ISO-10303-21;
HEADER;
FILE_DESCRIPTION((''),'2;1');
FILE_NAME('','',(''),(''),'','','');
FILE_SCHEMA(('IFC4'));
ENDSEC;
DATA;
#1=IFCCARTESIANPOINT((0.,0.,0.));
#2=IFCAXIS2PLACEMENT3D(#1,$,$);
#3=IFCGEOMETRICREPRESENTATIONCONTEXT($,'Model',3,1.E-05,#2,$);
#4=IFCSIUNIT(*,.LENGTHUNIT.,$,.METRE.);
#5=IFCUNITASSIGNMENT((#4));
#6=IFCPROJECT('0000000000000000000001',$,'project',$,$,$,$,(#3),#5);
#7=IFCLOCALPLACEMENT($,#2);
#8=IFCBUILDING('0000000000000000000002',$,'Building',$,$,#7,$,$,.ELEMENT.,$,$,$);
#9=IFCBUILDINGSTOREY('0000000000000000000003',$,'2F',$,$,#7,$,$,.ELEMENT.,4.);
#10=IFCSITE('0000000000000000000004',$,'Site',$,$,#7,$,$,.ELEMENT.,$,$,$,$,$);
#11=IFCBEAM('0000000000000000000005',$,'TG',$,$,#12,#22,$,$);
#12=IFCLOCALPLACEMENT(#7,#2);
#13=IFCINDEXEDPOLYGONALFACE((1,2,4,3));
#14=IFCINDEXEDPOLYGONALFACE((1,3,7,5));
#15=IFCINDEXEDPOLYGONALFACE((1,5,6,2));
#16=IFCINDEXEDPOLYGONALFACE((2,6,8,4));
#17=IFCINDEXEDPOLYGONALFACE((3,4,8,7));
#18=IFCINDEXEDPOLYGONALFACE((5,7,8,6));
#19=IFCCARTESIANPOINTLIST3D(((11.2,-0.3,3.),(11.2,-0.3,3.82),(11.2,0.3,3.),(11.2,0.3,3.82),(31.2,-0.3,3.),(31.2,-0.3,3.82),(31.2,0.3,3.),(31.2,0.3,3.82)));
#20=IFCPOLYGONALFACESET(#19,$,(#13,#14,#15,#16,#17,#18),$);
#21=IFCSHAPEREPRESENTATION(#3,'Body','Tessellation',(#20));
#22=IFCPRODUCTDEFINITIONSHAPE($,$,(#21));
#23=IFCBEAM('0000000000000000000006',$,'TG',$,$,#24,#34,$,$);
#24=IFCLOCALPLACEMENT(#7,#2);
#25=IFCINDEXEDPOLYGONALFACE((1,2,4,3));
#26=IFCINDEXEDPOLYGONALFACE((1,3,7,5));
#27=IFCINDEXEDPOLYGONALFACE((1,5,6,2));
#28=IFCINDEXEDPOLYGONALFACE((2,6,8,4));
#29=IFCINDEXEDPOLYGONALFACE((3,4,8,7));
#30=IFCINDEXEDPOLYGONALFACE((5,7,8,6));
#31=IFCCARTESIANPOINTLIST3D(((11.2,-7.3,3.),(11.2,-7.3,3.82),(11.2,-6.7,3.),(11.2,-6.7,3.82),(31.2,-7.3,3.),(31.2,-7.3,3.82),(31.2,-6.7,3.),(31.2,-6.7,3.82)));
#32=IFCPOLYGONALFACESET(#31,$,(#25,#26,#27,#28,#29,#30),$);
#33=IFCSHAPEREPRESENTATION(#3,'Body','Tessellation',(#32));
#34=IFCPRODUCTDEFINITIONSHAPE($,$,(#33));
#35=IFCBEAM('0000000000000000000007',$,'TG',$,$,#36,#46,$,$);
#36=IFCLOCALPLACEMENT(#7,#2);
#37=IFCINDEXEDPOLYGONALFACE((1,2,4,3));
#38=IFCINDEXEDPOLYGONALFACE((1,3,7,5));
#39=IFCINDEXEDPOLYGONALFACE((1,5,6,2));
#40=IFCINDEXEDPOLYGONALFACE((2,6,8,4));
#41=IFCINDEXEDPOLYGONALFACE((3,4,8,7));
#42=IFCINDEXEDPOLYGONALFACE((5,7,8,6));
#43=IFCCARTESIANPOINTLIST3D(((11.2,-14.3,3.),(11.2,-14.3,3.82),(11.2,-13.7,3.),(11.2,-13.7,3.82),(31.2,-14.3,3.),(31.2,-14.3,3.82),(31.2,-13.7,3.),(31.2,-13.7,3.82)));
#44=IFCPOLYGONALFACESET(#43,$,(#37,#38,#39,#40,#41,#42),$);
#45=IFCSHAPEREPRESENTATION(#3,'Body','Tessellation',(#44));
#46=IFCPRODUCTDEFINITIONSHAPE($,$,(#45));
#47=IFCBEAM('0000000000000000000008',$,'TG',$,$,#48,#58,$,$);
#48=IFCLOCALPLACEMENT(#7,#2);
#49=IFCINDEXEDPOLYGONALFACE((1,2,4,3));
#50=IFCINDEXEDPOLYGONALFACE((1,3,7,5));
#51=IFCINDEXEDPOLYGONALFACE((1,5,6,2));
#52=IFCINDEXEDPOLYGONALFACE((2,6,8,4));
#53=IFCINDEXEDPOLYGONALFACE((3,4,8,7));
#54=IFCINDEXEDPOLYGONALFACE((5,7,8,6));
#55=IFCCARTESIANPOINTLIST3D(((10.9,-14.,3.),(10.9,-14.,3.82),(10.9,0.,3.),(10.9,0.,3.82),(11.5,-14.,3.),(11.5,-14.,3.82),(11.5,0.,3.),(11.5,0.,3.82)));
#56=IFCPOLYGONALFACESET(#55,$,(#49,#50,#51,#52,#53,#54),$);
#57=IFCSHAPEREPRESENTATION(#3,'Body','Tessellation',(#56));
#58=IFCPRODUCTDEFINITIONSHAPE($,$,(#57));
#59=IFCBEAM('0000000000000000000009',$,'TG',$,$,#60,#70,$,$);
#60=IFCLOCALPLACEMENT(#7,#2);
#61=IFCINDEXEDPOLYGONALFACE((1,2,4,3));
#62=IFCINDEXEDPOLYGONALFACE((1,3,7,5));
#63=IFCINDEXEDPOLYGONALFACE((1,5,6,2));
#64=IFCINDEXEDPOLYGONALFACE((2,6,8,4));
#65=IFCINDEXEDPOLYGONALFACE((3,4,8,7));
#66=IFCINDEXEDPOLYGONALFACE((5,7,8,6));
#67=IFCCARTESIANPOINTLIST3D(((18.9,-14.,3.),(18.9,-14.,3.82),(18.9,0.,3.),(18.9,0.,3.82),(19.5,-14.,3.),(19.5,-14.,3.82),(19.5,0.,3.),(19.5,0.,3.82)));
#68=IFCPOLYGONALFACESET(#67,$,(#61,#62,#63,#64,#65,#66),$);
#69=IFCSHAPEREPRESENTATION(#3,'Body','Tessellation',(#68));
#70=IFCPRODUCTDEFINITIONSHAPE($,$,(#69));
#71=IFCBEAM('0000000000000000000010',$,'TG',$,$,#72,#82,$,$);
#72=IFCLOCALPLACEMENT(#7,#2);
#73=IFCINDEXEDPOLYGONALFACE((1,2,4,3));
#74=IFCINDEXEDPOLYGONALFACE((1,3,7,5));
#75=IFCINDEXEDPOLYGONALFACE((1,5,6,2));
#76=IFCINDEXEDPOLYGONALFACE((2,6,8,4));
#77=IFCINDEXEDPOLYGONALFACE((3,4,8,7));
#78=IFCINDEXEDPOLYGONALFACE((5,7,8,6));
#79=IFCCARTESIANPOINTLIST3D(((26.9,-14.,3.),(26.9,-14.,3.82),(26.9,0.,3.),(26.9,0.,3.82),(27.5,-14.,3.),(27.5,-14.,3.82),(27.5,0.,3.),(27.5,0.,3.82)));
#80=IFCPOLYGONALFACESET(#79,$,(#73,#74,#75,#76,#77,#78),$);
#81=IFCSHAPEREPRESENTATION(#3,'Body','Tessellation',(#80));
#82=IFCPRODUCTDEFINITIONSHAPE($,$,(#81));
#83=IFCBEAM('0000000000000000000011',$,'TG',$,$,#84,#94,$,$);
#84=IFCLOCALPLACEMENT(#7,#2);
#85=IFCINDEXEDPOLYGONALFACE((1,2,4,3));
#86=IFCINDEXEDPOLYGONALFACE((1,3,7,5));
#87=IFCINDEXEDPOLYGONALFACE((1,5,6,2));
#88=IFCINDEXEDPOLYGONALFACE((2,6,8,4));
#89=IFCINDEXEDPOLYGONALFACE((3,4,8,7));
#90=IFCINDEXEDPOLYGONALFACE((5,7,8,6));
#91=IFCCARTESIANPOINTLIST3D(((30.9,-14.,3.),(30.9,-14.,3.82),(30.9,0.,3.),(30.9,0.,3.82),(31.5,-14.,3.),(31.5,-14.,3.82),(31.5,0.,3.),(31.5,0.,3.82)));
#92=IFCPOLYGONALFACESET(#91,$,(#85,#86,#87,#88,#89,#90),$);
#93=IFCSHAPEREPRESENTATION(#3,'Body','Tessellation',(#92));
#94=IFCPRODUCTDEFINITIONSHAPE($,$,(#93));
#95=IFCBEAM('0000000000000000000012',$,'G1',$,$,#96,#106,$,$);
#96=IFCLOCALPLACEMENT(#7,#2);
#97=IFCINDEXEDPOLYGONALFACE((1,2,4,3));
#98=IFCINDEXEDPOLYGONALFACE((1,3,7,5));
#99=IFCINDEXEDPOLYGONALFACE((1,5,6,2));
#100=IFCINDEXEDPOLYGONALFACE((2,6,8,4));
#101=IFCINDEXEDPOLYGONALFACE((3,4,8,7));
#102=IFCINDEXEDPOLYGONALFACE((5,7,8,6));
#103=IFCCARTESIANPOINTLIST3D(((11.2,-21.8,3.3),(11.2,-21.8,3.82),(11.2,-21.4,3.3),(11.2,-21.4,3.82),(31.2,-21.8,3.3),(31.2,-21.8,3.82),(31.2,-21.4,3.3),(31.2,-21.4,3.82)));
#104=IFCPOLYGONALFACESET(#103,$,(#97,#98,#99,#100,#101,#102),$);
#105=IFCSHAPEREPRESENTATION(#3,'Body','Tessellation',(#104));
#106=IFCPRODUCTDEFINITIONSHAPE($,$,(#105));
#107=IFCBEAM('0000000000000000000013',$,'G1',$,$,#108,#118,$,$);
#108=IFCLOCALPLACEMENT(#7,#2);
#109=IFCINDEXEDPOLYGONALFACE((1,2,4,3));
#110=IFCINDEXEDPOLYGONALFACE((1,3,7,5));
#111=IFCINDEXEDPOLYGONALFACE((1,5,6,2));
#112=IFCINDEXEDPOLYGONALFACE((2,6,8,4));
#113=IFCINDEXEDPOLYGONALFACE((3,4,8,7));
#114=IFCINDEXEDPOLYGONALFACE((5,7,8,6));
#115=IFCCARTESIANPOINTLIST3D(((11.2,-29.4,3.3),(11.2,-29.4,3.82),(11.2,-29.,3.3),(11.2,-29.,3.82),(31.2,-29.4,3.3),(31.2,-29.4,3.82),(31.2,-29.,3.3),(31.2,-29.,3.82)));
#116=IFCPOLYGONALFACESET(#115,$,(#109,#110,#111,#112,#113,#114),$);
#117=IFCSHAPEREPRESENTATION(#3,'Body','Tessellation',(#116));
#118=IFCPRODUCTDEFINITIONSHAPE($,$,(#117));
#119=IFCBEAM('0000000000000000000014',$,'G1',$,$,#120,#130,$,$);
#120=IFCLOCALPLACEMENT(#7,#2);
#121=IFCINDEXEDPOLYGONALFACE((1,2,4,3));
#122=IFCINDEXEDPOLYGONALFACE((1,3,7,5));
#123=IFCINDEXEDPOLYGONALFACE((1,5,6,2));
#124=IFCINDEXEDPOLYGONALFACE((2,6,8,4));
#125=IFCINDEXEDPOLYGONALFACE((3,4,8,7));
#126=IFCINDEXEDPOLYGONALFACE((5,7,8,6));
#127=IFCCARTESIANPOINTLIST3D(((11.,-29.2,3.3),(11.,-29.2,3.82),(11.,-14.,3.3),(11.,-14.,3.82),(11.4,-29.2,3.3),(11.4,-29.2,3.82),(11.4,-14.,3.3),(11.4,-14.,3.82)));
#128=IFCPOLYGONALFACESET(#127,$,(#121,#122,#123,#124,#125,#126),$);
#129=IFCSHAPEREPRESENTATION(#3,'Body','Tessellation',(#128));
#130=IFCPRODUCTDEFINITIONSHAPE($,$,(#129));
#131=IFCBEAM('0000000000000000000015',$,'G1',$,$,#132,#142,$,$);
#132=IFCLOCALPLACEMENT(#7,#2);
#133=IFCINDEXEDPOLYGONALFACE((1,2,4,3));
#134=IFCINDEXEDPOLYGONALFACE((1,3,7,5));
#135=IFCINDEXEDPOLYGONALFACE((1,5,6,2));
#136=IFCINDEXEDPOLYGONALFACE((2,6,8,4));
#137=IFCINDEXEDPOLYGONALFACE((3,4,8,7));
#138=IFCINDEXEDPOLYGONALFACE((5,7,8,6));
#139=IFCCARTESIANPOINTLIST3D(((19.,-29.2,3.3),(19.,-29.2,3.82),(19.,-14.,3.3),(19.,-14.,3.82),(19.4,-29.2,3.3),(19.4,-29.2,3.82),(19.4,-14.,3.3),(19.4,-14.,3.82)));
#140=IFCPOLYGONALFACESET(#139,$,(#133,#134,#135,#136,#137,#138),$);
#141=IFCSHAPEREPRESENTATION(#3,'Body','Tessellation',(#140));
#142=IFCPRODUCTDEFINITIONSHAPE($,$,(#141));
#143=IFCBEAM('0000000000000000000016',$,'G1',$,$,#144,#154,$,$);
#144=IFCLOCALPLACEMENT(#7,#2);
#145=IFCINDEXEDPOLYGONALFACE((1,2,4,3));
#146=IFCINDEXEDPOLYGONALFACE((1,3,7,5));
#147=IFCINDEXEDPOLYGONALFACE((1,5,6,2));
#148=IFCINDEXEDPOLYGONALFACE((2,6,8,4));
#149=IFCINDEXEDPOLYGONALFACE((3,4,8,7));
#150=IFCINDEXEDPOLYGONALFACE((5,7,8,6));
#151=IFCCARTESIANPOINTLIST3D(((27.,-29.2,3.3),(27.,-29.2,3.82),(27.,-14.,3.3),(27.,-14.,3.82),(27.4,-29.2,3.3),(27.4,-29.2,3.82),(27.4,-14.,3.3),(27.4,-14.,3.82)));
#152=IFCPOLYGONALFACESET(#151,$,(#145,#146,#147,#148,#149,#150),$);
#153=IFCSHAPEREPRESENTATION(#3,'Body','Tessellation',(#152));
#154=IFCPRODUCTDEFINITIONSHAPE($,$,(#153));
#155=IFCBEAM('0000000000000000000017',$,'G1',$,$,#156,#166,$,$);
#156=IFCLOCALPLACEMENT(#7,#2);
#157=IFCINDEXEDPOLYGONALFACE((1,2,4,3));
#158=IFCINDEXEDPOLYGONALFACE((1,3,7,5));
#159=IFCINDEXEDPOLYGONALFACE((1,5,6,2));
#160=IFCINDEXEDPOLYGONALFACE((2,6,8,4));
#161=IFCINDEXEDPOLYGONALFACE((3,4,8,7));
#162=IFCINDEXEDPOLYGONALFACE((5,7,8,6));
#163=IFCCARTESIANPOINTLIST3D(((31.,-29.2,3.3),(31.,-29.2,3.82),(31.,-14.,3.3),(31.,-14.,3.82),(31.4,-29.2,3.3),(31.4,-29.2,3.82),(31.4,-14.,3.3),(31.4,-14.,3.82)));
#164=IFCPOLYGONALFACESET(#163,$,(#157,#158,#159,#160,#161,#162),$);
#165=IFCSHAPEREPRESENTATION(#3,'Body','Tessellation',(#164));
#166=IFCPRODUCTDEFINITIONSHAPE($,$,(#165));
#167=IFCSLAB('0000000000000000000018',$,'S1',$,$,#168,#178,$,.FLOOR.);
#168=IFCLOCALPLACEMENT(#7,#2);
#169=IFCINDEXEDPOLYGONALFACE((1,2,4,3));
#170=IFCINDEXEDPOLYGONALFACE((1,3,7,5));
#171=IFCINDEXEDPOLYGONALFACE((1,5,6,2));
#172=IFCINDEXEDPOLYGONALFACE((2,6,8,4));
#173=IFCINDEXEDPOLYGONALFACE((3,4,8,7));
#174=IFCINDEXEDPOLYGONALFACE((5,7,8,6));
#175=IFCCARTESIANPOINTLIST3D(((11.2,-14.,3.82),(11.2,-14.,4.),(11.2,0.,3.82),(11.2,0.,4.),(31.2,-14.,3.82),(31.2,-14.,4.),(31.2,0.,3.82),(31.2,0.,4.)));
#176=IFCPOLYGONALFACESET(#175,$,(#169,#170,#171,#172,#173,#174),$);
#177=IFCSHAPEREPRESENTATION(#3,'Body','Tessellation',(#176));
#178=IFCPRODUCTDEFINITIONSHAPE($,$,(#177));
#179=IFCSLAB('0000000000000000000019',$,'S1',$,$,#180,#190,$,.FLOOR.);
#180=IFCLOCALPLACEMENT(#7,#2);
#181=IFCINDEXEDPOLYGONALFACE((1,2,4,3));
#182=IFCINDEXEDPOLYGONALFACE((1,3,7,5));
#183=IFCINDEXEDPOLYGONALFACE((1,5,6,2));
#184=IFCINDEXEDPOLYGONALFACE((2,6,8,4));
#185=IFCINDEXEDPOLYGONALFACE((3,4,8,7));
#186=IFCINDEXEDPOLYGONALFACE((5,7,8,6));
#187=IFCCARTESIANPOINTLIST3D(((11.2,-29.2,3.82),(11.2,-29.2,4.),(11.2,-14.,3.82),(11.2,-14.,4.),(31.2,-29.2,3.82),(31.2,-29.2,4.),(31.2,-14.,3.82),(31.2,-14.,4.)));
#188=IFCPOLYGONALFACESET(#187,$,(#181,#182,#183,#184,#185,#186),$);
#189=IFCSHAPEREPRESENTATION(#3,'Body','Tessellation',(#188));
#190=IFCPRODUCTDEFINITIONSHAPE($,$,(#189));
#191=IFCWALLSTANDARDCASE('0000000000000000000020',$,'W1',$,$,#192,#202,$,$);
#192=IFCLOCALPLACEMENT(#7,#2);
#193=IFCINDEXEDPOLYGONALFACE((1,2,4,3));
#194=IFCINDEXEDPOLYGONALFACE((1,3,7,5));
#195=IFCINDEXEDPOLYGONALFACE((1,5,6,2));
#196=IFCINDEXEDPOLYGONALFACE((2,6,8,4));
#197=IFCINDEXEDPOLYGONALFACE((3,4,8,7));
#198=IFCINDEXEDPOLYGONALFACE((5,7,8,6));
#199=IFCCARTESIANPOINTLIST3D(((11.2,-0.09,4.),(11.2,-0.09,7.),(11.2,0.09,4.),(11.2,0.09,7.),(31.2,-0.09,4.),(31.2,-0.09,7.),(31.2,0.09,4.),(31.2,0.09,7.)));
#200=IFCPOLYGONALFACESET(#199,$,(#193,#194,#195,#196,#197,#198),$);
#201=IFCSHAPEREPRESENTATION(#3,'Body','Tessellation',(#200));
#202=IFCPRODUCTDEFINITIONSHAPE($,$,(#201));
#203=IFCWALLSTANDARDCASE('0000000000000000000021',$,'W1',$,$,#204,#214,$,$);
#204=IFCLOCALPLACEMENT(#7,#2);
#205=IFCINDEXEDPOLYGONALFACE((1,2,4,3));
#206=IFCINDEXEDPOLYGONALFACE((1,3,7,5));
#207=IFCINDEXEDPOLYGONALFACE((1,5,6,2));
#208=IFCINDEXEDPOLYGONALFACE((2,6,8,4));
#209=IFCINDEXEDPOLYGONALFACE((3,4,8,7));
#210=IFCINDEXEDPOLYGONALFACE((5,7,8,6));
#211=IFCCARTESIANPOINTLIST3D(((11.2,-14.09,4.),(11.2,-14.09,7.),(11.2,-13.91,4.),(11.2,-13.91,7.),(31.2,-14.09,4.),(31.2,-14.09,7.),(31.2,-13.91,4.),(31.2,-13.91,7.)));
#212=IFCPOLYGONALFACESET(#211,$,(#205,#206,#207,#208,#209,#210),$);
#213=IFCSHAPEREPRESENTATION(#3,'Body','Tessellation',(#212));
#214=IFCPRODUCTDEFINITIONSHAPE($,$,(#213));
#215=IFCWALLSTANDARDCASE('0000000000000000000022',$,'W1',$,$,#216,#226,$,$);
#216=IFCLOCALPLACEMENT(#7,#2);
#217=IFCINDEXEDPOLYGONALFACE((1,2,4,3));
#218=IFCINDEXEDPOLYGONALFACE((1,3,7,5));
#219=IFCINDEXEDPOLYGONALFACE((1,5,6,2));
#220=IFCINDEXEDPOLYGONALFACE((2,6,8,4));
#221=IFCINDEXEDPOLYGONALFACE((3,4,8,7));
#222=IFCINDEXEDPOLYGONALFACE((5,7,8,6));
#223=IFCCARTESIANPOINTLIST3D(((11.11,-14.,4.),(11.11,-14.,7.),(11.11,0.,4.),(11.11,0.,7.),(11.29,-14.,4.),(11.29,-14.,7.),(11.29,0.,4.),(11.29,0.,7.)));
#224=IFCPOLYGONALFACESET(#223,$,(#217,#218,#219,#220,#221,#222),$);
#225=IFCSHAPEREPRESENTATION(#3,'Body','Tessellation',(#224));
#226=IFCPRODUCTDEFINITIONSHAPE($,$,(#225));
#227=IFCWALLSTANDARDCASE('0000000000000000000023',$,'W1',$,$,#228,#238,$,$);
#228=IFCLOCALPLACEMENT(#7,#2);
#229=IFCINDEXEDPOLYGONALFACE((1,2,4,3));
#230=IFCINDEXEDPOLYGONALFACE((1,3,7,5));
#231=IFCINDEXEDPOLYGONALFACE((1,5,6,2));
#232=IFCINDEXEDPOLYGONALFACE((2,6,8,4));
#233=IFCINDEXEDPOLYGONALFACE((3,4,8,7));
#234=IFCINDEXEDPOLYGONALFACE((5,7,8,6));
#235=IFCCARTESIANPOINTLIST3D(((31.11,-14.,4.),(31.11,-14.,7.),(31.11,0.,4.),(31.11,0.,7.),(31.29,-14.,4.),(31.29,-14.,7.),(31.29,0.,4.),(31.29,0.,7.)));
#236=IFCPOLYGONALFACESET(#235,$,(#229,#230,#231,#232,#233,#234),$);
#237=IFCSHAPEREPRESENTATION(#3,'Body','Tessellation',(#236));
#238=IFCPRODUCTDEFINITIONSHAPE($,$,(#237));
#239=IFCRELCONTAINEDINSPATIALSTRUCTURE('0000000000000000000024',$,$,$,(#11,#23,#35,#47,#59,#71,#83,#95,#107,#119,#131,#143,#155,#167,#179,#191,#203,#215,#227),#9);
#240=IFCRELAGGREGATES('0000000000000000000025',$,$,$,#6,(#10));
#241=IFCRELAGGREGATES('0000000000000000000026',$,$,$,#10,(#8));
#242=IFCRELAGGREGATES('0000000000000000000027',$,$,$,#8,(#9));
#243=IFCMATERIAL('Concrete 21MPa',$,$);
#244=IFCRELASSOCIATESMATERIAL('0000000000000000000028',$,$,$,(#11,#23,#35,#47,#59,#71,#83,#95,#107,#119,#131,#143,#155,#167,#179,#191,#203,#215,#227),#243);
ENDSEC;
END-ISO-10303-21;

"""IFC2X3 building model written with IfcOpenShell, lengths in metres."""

from ifc_helpers import new_model, si_unit, frame, origin, origin_2d, place, context, project, spatial, rectangle, extrude, material, element, save


model = new_model("IFC2X3")

# Units and contexts
model_context = context("Model", 3, precision=1e-05, world=origin())
ifc_project = project(units=[si_unit("LENGTHUNIT", "METRE")], contexts=[model_context])

# Site, building, storey
placement = place(None, origin())
site = spatial("IfcSite", under=ifc_project, at=placement, Name="Site", CompositionType="ELEMENT")
building = spatial("IfcBuilding", under=site, at=placement, Name="Building", CompositionType="ELEMENT")
storey = spatial("IfcBuildingStorey", under=building, at=placement, Name="2F", CompositionType="ELEMENT", Elevation=4.0)

# Beams
ifc_material_1 = material(Name="Concrete 21MPa")
for number, where, name in (
    (1, (21.2, 0.0, 3.0), "TG"),
    (2, (21.2, -7.0, 3.0), "TG"),
    (3, (21.2, -14.0, 3.0), "TG"),
):
    element("IfcBeam", number, at=place(None, frame(where)), inside=storey, material=ifc_material_1, Name=name, context=model_context, shape_type="SweptSolid", body=[
        extrude(rectangle(XDim=20.0, YDim=0.6, at=origin_2d()), origin(), (0.0, 0.0, 1.0), 0.82),
    ])
for number, where, name in (
    (4, (11.2, -7.0, 3.0), "TG"),
    (5, (19.2, -7.0, 3.0), "TG"),
    (6, (27.2, -7.0, 3.0), "TG"),
    (7, (31.2, -7.0, 3.0), "TG"),
):
    element("IfcBeam", number, at=place(None, frame(where)), inside=storey, material=ifc_material_1, Name=name, context=model_context, shape_type="SweptSolid", body=[
        extrude(rectangle(XDim=0.6, YDim=14.0, at=origin_2d()), origin(), (0.0, 0.0, 1.0), 0.82),
    ])
for number, where, name in (
    (8, (21.2, -21.6, 3.3), "G1"),
    (9, (21.2, -29.2, 3.3), "G1"),
):
    element("IfcBeam", number, at=place(None, frame(where)), inside=storey, material=ifc_material_1, Name=name, context=model_context, shape_type="SweptSolid", body=[
        extrude(rectangle(XDim=20.0, YDim=0.4, at=origin_2d()), origin(), (0.0, 0.0, 1.0), 0.52),
    ])
for number, where, name in (
    (10, (11.2, -21.6, 3.3), "G1"),
    (11, (19.2, -21.6, 3.3), "G1"),
    (12, (27.2, -21.6, 3.3), "G1"),
    (13, (31.2, -21.6, 3.3), "G1"),
):
    element("IfcBeam", number, at=place(None, frame(where)), inside=storey, material=ifc_material_1, Name=name, context=model_context, shape_type="SweptSolid", body=[
        extrude(rectangle(XDim=0.4, YDim=15.2, at=origin_2d()), origin(), (0.0, 0.0, 1.0), 0.52),
    ])

# Slabs
slab_1_placement = place(None, frame((21.2, -7.0, 3.82)))
element("IfcSlab", 14, at=slab_1_placement, inside=storey, material=ifc_material_1, Name="S1", PredefinedType="FLOOR", context=model_context, shape_type="SweptSolid", body=[
    extrude(rectangle(XDim=20.0, YDim=14.0, at=origin_2d()), origin(), (0.0, 0.0, 1.0), 0.18),
])
slab_2_placement = place(None, frame((21.2, -21.6, 3.82)))
element("IfcSlab", 15, at=slab_2_placement, inside=storey, material=ifc_material_1, Name="S1", PredefinedType="FLOOR", context=model_context, shape_type="SweptSolid", body=[
    extrude(rectangle(XDim=20.0, YDim=15.2, at=origin_2d()), origin(), (0.0, 0.0, 1.0), 0.18),
])

# Walls
for number, where, name in (
    (16, (21.2, 0.0, 4.0), "W1"),
    (17, (21.2, -14.0, 4.0), "W1"),
):
    element("IfcWallStandardCase", number, at=place(None, frame(where)), inside=storey, material=ifc_material_1, Name=name, context=model_context, shape_type="SweptSolid", body=[
        extrude(rectangle(XDim=20.0, YDim=0.18, at=origin_2d()), origin(), (0.0, 0.0, 1.0), 3.0),
    ])
for number, where, name in (
    (18, (11.2, -7.0, 4.0), "W1"),
    (19, (31.2, -7.0, 4.0), "W1"),
):
    element("IfcWallStandardCase", number, at=place(None, frame(where)), inside=storey, material=ifc_material_1, Name=name, context=model_context, shape_type="SweptSolid", body=[
        extrude(rectangle(XDim=0.18, YDim=14.0, at=origin_2d()), origin(), (0.0, 0.0, 1.0), 3.0),
    ])

save(model, "model.ifc")
